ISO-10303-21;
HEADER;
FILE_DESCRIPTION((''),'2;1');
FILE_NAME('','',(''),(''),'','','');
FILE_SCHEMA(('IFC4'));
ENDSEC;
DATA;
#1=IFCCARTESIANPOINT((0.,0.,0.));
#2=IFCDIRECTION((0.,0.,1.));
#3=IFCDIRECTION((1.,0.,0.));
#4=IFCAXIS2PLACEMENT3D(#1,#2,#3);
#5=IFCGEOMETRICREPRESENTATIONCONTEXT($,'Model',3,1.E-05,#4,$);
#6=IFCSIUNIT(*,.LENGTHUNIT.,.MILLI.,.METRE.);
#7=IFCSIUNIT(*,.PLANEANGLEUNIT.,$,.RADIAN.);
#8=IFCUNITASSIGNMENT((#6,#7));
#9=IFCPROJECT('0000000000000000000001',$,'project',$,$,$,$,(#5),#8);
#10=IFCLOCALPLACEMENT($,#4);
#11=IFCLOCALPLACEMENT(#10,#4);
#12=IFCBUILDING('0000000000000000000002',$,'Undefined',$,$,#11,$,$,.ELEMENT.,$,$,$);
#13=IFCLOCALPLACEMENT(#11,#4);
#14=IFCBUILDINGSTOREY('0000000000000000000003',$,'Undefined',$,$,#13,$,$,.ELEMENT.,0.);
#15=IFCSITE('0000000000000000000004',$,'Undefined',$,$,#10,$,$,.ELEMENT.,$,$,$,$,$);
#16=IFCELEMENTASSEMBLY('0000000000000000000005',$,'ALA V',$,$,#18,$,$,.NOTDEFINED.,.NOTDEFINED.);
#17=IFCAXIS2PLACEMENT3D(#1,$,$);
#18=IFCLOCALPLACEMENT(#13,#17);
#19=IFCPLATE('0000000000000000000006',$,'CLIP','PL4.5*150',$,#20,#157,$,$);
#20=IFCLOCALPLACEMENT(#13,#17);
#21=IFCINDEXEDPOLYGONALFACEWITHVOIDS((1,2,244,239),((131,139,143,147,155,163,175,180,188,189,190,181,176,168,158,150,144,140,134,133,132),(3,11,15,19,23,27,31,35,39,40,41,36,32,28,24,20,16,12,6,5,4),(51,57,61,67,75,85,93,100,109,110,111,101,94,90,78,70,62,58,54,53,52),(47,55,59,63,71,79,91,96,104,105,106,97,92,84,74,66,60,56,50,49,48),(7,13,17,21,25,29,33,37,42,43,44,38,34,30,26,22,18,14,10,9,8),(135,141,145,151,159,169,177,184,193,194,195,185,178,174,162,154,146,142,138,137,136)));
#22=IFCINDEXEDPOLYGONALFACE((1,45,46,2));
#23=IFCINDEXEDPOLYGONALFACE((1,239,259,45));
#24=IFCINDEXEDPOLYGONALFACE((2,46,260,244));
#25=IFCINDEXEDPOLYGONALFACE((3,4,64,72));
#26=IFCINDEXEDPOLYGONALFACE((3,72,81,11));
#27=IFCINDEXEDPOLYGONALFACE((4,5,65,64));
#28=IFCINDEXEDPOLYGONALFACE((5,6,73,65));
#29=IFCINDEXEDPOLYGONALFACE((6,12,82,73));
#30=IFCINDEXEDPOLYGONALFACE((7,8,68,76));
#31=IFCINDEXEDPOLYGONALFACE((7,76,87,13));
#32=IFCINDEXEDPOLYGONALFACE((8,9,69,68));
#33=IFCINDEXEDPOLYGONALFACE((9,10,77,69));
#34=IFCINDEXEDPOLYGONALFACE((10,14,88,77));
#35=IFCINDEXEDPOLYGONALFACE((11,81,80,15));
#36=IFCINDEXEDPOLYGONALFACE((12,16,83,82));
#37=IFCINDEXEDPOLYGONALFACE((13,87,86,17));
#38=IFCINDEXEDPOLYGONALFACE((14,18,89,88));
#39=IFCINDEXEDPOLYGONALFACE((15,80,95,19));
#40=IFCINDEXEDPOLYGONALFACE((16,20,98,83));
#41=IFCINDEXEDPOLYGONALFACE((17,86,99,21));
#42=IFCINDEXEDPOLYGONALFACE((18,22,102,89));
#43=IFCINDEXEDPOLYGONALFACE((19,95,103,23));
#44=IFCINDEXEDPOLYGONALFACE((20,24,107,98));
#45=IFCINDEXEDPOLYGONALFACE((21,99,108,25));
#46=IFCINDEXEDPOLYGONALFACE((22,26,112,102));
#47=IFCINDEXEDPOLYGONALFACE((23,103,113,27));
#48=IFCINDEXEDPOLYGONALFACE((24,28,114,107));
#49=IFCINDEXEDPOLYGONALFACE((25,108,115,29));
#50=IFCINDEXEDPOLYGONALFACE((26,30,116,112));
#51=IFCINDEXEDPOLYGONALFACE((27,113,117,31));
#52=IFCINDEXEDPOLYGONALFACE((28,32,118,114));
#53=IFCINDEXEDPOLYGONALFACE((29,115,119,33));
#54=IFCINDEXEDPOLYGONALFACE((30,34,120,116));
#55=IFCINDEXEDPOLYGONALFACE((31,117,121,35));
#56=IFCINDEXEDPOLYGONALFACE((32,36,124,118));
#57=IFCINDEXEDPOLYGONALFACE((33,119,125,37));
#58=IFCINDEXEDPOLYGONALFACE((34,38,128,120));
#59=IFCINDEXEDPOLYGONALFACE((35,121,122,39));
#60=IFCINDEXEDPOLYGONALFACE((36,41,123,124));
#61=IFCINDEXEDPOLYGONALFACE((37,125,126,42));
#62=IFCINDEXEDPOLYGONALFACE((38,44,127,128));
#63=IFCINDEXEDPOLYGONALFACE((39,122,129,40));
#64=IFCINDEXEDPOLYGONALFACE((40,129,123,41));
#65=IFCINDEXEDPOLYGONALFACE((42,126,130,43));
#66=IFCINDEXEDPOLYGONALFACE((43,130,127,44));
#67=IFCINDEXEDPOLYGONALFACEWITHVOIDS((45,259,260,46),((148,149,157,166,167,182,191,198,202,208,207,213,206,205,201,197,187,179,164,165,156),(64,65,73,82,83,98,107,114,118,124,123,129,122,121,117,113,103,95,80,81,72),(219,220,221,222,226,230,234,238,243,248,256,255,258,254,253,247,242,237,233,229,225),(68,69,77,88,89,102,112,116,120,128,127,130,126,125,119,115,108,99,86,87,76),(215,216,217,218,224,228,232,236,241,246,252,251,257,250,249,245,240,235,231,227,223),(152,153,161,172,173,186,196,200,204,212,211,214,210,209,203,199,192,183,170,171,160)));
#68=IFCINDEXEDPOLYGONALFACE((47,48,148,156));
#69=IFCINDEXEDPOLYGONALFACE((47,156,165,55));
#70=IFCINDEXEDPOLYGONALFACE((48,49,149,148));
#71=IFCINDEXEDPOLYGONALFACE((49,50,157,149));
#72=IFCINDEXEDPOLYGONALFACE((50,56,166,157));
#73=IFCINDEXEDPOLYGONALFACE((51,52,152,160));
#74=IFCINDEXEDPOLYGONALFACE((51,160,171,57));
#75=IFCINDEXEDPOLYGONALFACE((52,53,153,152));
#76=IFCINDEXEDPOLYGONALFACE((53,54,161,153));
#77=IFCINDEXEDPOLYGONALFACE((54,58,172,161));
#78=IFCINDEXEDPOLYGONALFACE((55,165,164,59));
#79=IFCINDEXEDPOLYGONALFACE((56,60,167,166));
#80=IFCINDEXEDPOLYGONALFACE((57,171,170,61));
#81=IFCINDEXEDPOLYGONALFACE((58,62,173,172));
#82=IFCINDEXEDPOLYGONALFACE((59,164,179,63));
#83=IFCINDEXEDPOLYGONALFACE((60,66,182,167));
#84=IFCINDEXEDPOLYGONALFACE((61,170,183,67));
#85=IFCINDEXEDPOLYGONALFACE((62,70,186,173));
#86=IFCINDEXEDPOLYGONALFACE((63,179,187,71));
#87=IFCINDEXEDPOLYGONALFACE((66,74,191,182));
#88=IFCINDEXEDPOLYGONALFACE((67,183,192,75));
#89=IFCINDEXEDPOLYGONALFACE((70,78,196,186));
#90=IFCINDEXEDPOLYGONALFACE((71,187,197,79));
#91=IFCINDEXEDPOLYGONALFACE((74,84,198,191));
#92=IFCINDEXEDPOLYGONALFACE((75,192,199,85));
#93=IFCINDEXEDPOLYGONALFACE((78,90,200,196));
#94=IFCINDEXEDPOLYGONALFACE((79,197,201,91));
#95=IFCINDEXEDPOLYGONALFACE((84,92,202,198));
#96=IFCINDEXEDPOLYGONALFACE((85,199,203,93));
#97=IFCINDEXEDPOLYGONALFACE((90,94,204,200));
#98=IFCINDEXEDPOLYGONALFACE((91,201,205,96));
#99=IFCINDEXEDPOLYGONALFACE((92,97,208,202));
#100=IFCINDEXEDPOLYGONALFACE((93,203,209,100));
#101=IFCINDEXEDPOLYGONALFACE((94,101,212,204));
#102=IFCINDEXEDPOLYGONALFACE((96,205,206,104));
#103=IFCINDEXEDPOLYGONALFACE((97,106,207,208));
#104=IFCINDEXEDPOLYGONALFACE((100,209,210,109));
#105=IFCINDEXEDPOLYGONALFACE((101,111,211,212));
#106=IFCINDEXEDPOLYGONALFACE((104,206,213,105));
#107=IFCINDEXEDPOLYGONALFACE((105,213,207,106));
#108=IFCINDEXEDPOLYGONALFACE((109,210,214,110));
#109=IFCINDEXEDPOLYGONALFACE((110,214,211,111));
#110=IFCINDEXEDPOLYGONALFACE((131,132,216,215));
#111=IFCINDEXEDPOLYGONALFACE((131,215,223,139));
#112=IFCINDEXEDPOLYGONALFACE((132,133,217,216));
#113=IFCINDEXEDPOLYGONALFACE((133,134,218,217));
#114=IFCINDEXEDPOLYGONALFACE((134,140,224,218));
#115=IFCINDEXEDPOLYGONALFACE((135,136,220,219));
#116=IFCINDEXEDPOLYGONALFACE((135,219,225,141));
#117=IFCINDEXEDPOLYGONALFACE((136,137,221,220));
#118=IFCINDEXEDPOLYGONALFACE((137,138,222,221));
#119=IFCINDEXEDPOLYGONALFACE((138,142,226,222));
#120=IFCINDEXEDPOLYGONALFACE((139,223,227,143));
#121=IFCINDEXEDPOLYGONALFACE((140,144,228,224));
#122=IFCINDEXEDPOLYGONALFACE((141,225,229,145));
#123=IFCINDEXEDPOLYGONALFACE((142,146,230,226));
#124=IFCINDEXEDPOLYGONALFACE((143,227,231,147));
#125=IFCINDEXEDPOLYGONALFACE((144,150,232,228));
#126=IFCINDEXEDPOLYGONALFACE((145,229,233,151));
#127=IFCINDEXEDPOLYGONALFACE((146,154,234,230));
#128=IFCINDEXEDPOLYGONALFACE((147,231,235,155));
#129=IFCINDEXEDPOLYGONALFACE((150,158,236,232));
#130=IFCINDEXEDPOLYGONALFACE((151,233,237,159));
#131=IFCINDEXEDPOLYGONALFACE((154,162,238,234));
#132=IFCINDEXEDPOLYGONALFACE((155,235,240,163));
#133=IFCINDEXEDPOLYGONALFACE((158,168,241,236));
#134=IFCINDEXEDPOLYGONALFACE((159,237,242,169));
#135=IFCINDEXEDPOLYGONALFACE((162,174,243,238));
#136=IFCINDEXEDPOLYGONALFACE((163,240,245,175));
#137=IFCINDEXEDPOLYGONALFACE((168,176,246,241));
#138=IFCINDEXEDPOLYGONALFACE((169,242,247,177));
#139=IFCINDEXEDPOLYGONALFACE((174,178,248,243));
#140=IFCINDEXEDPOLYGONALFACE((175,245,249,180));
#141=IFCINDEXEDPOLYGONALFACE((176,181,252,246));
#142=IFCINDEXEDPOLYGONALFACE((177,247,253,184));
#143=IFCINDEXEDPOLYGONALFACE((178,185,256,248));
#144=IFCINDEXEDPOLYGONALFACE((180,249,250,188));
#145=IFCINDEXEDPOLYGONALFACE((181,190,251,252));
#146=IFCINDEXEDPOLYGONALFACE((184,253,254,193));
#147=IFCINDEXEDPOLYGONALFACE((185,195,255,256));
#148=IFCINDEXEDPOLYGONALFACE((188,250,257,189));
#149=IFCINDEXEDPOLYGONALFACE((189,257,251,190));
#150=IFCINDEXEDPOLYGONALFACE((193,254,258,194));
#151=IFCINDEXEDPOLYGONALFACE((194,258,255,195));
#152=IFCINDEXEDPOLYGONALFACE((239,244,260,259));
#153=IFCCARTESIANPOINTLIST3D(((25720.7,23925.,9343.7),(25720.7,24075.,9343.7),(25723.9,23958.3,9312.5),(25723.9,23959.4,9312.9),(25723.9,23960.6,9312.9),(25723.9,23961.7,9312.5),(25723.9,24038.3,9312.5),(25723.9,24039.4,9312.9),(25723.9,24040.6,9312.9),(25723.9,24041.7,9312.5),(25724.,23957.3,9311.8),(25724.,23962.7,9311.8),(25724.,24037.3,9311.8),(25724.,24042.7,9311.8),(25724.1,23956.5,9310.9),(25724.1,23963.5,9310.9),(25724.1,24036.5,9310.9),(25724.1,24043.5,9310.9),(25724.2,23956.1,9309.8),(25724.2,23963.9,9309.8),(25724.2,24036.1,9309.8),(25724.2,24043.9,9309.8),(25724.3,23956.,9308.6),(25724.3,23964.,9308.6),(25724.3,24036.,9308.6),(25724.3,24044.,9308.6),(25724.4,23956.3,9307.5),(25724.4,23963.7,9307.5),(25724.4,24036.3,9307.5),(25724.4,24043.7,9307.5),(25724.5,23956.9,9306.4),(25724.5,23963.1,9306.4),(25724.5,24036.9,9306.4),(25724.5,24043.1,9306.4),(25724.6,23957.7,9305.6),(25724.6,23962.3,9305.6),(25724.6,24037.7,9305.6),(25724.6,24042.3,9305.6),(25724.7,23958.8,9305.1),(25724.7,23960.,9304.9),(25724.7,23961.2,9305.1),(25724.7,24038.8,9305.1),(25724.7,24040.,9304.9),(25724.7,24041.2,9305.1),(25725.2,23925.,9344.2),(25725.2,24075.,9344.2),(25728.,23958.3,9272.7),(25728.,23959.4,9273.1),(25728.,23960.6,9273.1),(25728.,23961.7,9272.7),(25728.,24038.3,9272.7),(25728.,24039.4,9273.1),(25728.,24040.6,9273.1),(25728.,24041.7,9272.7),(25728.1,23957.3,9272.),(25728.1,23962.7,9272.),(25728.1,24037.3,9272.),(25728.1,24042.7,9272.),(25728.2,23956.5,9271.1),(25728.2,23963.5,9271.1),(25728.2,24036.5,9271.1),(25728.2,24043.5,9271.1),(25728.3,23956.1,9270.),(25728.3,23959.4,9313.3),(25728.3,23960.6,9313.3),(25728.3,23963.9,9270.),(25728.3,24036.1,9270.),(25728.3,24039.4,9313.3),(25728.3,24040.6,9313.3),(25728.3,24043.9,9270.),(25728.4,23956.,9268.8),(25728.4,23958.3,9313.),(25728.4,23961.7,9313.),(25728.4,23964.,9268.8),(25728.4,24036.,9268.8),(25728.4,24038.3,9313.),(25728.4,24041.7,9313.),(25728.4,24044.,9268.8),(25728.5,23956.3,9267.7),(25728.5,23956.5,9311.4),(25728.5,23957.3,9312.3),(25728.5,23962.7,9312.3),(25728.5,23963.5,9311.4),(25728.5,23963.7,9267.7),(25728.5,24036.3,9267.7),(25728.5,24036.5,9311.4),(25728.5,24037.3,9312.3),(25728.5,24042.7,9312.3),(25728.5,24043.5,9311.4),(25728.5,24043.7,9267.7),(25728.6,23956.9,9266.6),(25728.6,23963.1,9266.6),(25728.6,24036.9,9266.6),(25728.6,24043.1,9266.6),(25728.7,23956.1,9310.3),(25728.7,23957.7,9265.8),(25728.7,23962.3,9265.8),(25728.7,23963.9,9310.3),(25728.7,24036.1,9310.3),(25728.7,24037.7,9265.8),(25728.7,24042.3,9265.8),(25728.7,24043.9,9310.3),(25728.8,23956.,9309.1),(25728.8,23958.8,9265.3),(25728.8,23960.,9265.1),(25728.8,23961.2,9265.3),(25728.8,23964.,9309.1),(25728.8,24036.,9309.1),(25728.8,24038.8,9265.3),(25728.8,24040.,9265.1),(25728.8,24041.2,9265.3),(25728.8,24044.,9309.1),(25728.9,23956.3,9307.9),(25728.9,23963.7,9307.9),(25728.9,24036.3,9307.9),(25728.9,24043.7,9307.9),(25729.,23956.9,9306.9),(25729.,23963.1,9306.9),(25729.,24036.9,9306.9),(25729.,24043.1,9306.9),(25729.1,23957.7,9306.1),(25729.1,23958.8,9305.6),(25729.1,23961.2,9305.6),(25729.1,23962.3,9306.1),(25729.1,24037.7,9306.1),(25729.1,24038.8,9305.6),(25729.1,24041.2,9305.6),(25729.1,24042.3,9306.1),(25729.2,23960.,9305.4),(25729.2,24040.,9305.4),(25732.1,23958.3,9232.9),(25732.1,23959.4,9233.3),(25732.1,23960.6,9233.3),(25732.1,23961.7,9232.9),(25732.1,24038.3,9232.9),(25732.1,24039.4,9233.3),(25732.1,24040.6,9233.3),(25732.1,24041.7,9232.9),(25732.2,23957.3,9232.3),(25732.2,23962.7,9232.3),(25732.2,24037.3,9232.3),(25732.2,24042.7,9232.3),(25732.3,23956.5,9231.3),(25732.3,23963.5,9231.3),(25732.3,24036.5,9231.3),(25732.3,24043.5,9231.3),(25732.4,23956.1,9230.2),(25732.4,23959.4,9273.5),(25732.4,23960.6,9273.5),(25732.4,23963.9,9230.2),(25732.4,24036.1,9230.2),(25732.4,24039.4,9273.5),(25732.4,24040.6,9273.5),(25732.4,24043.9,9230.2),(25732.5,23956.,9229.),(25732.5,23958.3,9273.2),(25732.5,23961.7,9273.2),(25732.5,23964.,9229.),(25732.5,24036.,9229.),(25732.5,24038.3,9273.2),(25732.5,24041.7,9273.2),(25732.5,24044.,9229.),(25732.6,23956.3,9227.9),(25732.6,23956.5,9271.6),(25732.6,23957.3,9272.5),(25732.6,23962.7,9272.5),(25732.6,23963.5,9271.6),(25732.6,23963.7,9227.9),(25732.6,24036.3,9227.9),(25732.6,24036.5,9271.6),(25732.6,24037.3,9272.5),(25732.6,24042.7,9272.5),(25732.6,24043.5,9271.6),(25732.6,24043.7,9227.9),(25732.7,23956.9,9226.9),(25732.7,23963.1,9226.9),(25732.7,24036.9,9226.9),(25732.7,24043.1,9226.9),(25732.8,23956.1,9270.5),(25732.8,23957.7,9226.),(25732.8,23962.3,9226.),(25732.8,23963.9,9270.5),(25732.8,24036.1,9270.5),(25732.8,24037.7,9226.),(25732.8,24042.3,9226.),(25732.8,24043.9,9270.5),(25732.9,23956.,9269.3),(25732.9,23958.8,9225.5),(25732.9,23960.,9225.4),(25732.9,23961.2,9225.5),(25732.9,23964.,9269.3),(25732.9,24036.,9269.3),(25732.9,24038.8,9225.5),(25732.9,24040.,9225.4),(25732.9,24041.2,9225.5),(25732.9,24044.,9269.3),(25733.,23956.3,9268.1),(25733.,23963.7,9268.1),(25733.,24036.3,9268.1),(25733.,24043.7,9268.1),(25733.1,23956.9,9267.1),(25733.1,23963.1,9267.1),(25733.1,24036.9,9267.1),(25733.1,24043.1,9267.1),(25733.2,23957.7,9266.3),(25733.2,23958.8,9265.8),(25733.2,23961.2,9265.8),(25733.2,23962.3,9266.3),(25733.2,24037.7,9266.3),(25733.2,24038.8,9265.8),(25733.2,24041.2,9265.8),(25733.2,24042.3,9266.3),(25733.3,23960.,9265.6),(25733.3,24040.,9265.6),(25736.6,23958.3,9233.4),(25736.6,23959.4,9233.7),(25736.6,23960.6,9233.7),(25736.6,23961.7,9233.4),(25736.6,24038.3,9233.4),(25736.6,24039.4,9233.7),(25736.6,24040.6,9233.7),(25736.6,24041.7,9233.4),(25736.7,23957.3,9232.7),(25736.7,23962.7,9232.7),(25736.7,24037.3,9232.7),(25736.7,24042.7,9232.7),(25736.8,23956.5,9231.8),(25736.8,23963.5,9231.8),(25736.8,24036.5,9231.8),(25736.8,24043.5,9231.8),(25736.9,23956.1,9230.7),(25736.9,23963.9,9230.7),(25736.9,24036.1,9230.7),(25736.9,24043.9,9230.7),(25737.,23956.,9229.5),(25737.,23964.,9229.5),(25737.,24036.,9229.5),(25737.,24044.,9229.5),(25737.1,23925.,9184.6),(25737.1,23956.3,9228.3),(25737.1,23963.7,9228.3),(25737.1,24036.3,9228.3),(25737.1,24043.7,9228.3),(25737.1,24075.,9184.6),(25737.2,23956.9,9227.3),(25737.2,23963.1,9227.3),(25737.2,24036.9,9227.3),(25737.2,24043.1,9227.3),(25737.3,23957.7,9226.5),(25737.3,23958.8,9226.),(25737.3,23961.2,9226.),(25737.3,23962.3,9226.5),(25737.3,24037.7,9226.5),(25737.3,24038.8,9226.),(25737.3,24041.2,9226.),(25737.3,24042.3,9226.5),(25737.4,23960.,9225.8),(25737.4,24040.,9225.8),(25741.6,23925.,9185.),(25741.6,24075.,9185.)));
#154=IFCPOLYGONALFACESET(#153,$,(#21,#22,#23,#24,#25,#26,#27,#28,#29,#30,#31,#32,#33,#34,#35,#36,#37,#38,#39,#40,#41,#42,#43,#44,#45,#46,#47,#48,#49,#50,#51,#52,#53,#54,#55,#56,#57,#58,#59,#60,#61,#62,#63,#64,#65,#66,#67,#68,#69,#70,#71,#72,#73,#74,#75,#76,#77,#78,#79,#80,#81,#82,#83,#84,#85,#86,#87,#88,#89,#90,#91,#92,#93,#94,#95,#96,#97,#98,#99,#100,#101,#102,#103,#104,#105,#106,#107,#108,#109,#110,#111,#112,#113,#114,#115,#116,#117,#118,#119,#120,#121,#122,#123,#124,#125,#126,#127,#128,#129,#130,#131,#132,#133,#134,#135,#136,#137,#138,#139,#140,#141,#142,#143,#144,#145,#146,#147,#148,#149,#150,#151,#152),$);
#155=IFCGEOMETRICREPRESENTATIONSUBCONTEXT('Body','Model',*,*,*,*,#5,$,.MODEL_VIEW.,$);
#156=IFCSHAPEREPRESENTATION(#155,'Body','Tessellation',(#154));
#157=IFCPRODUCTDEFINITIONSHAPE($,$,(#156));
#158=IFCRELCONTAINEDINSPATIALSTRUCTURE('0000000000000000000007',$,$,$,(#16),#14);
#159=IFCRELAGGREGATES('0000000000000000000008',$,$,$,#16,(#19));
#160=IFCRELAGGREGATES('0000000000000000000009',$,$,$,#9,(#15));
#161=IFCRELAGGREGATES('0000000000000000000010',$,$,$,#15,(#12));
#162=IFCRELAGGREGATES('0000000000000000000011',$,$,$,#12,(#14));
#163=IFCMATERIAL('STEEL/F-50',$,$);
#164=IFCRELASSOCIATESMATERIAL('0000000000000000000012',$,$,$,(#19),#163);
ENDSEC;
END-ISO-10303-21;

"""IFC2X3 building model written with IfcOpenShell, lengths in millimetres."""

from ifc_helpers import new_model, si_unit, frame, origin_with_axes, origin_2d_with_axis, place, context, subcontext, project, spatial, polyline, circle, outline, extrude, source, transform, mapped, material, element, aggregate, save


model = new_model("IFC2X3")

# Units and contexts
model_context = context("Model", 3, precision=1e-05, world=origin_with_axes())
body_context = subcontext(model_context, "Body", "Model", "MODEL_VIEW")
ifc_project = project(units=[si_unit("LENGTHUNIT", "METRE", prefix="MILLI"), si_unit("PLANEANGLEUNIT", "RADIAN")], contexts=[model_context])

# Site, building, storey
site_placement = place(None, origin_with_axes())
site = spatial("IfcSite", under=ifc_project, at=site_placement, Name="Undefined", CompositionType="ELEMENT")
building_placement = place(site_placement, origin_with_axes())
building = spatial("IfcBuilding", under=site, at=building_placement, Name="Undefined", CompositionType="ELEMENT")
storey_placement = place(building_placement, origin_with_axes())
storey = spatial("IfcBuildingStorey", under=building, at=storey_placement, Name="Undefined", CompositionType="ELEMENT", Elevation=0.0)

# Shared definitions
ifc_material_1 = material(Name="STEEL/F-50")

# Element assembly, plate, openings
assembly_1_placement = place(storey_placement, origin_with_axes())
assembly_1 = element("IfcElementAssembly", 1, at=assembly_1_placement, inside=storey, Name="ALA V", AssemblyPlace="NOTDEFINED", PredefinedType="NOTDEFINED")
shared_shape_1 = source(origin_with_axes(), body_context, "Body", "SweptSolid", [
    extrude(circle(Radius=4.0, at=origin_2d_with_axis()), frame((0.0, -4.6, 0.0), z_axis=(0.0, 1.0, 0.0), x_axis=(1.0, 0.0, 0.0)), (0.0, 0.0, 1.0), 4.7),
])
plate_1_placement = place(assembly_1_placement, frame((25722.9, 23925.0, 9344.0), z_axis=(0.994727, 0.0, 0.102562), x_axis=(0.102562, 0.0, -0.994727)))
plate_1 = element("IfcPlate", 2, at=plate_1_placement, material=ifc_material_1, Name="CLIP", Description="PL4.5*150", context=body_context, shape_type="SweptSolid", body=[
    extrude(outline(polyline([(0.0, 0.0), (160.0, 0.0), (160.0, 150.0), (0.0, 150.0), (0.0, 0.0)])), frame((0.0, 0.0, -2.2), z_axis=(0.0, 0.0, 1.0), x_axis=(1.0, 0.0, 0.0)), (0.0, 0.0, 1.0), 4.5),
])
opening_1_placement = place(assembly_1_placement, frame((25724.3, 24040.0, 9308.9), z_axis=(0.0, 1.0, 0.0), x_axis=(0.102562, 0.0, -0.994727)))
element("IfcOpeningElement", 3, at=opening_1_placement, cuts=plate_1, ObjectType="Opening", context=body_context, shape_type="MappedRepresentation", body=[
    mapped(shared_shape_1, transform((0.0, 0.0, 0.0))),
    mapped(shared_shape_1, transform((40.0, 0.0, 0.0))),
    mapped(shared_shape_1, transform((80.0, 0.0, 0.0))),
])
opening_2_placement = place(assembly_1_placement, frame((25724.3, 23960.0, 9308.9), z_axis=(0.0, 1.0, 0.0), x_axis=(0.102562, 0.0, -0.994727)))
element("IfcOpeningElement", 4, at=opening_2_placement, cuts=plate_1, ObjectType="Opening", context=body_context, shape_type="MappedRepresentation", body=[
    mapped(shared_shape_1, transform((0.0, 0.0, 0.0))),
    mapped(shared_shape_1, transform((40.0, 0.0, 0.0))),
    mapped(shared_shape_1, transform((80.0, 0.0, 0.0))),
])

aggregate(assembly_1, [plate_1])

save(model, "model.ifc")
